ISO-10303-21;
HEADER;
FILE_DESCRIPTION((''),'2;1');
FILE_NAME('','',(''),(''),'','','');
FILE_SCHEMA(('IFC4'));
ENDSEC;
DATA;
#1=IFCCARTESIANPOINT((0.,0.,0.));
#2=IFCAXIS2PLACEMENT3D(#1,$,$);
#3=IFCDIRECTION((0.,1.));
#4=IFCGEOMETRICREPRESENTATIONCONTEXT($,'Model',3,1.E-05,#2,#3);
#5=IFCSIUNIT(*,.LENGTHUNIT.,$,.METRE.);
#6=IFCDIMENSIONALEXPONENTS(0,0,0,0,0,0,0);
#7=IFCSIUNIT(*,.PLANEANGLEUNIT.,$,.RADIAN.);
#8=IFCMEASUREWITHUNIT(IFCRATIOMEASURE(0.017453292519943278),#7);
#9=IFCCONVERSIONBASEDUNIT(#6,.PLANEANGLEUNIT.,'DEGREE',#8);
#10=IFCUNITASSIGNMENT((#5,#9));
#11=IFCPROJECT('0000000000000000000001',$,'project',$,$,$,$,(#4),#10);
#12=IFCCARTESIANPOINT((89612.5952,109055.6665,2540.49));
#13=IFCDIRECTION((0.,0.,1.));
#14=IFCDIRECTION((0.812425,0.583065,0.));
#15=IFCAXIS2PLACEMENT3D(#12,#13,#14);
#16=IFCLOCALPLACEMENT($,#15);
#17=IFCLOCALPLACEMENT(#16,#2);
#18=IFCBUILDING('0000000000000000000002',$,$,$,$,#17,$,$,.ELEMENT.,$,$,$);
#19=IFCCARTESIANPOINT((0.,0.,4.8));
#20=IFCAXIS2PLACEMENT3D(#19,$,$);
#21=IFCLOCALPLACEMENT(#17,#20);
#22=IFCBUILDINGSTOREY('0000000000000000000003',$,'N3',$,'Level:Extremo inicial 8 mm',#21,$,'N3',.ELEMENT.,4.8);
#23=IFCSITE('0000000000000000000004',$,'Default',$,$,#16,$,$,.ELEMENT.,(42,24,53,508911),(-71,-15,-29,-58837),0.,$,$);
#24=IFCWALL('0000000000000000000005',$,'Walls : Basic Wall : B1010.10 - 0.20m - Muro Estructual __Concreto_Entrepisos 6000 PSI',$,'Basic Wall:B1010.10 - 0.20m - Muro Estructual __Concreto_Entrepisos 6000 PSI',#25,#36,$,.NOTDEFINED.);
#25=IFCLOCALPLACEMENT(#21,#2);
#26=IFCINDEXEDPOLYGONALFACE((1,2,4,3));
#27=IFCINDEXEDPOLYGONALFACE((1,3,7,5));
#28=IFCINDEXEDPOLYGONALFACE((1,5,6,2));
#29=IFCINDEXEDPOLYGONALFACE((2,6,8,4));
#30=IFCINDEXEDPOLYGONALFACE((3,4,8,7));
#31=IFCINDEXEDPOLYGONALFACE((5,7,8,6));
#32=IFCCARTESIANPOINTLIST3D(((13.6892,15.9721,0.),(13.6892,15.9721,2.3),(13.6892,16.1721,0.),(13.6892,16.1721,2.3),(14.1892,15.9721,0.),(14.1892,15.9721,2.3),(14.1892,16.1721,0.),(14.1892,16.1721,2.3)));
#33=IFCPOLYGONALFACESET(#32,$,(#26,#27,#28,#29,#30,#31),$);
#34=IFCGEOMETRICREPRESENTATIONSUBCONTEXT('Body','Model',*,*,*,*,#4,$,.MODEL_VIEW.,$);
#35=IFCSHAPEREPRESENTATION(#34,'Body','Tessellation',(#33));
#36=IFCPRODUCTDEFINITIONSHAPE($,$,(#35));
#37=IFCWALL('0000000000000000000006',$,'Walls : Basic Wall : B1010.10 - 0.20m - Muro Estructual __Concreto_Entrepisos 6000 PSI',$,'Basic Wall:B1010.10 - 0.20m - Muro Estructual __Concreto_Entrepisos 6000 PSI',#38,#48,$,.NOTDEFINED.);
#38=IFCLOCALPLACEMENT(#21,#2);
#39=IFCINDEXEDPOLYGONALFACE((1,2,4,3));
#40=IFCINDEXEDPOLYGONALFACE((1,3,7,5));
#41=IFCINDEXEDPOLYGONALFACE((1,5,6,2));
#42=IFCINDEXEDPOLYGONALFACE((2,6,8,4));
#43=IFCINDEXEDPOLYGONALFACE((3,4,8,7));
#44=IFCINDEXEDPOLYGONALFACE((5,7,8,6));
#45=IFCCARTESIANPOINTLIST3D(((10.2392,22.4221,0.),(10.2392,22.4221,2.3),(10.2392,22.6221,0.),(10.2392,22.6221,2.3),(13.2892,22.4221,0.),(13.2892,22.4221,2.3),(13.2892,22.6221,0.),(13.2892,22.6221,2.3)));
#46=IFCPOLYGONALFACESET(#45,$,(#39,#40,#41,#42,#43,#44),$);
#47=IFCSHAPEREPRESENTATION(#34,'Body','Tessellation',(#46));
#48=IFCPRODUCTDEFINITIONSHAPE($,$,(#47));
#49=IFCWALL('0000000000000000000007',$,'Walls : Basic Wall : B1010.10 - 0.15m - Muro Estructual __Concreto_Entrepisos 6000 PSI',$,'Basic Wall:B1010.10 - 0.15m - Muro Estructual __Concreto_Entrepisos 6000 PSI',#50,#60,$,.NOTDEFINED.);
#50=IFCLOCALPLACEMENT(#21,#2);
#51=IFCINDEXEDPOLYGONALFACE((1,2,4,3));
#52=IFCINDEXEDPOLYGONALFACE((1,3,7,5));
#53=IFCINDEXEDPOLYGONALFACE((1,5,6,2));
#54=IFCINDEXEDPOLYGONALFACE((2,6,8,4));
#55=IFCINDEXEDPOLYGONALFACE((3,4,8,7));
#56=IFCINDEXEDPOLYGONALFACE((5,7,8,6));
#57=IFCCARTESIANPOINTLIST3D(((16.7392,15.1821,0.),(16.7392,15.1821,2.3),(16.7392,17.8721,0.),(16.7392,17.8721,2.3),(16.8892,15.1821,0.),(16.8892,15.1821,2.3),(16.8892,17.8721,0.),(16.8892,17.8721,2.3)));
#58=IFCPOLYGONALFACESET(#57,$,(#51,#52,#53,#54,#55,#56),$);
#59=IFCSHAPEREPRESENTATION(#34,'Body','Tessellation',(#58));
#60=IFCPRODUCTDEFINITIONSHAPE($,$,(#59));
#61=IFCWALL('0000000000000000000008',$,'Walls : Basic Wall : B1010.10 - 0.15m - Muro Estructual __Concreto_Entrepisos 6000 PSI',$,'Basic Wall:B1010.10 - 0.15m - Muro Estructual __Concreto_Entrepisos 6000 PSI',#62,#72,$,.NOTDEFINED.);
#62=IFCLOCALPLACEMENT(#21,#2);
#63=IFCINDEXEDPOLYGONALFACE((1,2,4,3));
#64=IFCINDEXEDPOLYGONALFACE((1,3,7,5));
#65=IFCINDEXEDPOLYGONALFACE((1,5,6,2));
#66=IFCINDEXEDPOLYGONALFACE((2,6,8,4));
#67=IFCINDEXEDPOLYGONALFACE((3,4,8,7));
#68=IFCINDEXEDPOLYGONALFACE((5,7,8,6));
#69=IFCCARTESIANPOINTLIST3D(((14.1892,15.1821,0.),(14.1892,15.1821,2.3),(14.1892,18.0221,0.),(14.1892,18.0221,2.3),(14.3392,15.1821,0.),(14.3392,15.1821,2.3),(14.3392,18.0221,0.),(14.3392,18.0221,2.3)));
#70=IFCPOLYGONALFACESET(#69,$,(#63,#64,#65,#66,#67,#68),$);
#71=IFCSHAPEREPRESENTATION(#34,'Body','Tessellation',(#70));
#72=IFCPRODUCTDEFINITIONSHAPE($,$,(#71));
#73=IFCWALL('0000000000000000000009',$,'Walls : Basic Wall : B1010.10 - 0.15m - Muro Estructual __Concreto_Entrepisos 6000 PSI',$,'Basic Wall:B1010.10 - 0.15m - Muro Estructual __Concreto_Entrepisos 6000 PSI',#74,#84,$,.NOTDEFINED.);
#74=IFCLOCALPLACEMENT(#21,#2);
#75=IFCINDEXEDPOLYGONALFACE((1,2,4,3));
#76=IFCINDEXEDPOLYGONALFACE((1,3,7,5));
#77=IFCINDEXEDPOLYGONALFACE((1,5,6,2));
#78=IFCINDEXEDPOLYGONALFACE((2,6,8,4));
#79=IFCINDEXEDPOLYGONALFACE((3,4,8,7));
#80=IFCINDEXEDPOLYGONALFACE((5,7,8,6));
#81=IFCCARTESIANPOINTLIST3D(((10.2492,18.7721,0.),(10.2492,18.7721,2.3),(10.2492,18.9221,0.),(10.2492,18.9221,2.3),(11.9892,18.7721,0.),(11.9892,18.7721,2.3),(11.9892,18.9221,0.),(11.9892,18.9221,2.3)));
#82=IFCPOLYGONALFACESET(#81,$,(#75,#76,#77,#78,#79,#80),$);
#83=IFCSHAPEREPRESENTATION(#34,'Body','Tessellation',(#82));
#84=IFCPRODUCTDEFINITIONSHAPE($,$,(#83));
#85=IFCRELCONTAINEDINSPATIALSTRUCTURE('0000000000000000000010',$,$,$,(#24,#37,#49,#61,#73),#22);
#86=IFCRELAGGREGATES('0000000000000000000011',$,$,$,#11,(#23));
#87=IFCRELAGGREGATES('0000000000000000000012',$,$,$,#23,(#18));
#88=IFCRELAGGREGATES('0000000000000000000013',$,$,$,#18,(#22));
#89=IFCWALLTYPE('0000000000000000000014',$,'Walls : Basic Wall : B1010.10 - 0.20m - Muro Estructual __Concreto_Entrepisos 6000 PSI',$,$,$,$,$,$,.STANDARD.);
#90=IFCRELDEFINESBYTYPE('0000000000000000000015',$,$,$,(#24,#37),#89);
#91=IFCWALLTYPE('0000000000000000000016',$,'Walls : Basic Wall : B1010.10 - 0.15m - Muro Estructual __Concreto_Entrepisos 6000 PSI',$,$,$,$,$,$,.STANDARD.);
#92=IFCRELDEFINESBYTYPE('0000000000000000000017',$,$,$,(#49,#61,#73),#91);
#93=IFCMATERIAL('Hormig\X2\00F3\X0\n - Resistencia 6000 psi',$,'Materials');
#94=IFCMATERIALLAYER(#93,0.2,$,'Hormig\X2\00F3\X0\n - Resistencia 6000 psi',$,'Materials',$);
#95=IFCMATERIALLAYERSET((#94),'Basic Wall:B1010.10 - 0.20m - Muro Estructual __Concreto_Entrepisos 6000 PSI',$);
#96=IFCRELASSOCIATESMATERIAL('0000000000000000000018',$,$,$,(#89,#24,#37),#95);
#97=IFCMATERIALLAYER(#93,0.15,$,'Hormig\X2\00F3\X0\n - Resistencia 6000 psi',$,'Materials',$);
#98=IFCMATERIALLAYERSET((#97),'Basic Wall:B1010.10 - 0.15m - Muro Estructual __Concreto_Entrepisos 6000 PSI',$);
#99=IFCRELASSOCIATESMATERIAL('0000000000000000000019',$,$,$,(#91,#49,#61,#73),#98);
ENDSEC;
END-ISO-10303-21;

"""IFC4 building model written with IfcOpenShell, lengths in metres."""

from ifc_helpers import new_model, entity, si_unit, converted_unit, direction, frame, frame_2d, origin, place, context, subcontext, project, spatial, rectangle, extrude, material, layer, layer_set, layer_usage, type_object, element, save


model = new_model("IFC4")

# Units and contexts
model_context = context("Model", 3, precision=1e-05, world=origin(), true_north=direction((0.0, 1.0)))
body_context = subcontext(model_context, "Body", "Model", "MODEL_VIEW")
ifc_project = project(units=[si_unit("LENGTHUNIT", "METRE"), converted_unit("PLANEANGLEUNIT", "DEGREE", entity("IfcRatioMeasure", 0.017453292519943278), si_unit("PLANEANGLEUNIT", "RADIAN"), dimensions=[0, 0, 0, 0, 0, 0, 0])], contexts=[model_context])

# Site, building, storey
site_placement = place(None, frame((89612.5952, 109055.6665, 2540.49), z_axis=(0.0, 0.0, 1.0), x_axis=(0.812425, 0.583065, 0.0)))
site = spatial("IfcSite", under=ifc_project, at=site_placement, Name="Default", CompositionType="ELEMENT", RefLatitude=(42, 24, 53, 508911), RefLongitude=(-71, -15, -29, -58837), RefElevation=0.0)
building_placement = place(site_placement, origin())
building = spatial("IfcBuilding", under=site, at=building_placement, CompositionType="ELEMENT")
storey_placement = place(building_placement, frame((0.0, 0.0, 4.8)))
storey = spatial("IfcBuildingStorey", under=building, at=storey_placement, Name="N3", ObjectType="Level:Extremo inicial 8 mm", LongName="N3", CompositionType="ELEMENT", Elevation=4.8)

# Walls
ifc_material_1 = material(Name="Hormigón - Resistencia 6000 psi", Category="Materials")
ifc_layer_1 = layer(ifc_material_1, 0.2, Name="Hormigón - Resistencia 6000 psi", Category="Materials")
ifc_layer_set_1 = layer_set([ifc_layer_1], Name="Basic Wall:B1010.10 - 0.20m - Muro Estructual __Concreto_Entrepisos 6000 PSI")
wall_type_1 = type_object("IfcWallType", Name="Walls : Basic Wall : B1010.10 - 0.20m - Muro Estructual __Concreto_Entrepisos 6000 PSI", PredefinedType="STANDARD", material=ifc_layer_set_1)
ifc_layer_usage_1 = layer_usage(ifc_layer_set_1, "AXIS2", "NEGATIVE", 0.1)
wall_1_placement = place(storey_placement, frame((13.6892, 16.0721, 0.0)))
element("IfcWall", 1, at=wall_1_placement, inside=storey, type_object=wall_type_1, material=ifc_layer_usage_1, Name="Walls : Basic Wall : B1010.10 - 0.20m - Muro Estructual __Concreto_Entrepisos 6000 PSI", ObjectType="Basic Wall:B1010.10 - 0.20m - Muro Estructual __Concreto_Entrepisos 6000 PSI", PredefinedType="NOTDEFINED", context=body_context, shape_type="SweptSolid", body=[
    extrude(rectangle(XDim=0.5, YDim=0.2, at=frame_2d((0.25, 0.0), x_axis=(-1.0, 0.0))), origin(), (0.0, 0.0, 1.0), 2.3),
])
ifc_layer_usage_2 = layer_usage(ifc_layer_set_1, "AXIS2", "POSITIVE", -0.1)
wall_2_placement = place(storey_placement, frame((10.2392, 22.5221, 0.0)))
element("IfcWall", 2, at=wall_2_placement, inside=storey, type_object=wall_type_1, material=ifc_layer_usage_2, Name="Walls : Basic Wall : B1010.10 - 0.20m - Muro Estructual __Concreto_Entrepisos 6000 PSI", ObjectType="Basic Wall:B1010.10 - 0.20m - Muro Estructual __Concreto_Entrepisos 6000 PSI", PredefinedType="NOTDEFINED", context=body_context, shape_type="SweptSolid", body=[
    extrude(rectangle(XDim=3.05, YDim=0.2, at=frame_2d((1.525, 0.0), x_axis=(-1.0, 0.0))), origin(), (0.0, 0.0, 1.0), 2.3),
])
ifc_layer_2 = layer(ifc_material_1, 0.15, Name="Hormigón - Resistencia 6000 psi", Category="Materials")
ifc_layer_set_2 = layer_set([ifc_layer_2], Name="Basic Wall:B1010.10 - 0.15m - Muro Estructual __Concreto_Entrepisos 6000 PSI")
ifc_layer_usage_3 = layer_usage(ifc_layer_set_2, "AXIS2", "NEGATIVE", 0.075)
wall_type_2 = type_object("IfcWallType", Name="Walls : Basic Wall : B1010.10 - 0.15m - Muro Estructual __Concreto_Entrepisos 6000 PSI", PredefinedType="STANDARD", material=ifc_layer_set_2)
wall_3_placement = place(storey_placement, frame((16.8142, 15.1821, 0.0), z_axis=(0.0, 0.0, 1.0), x_axis=(0.0, 1.0, 0.0)))
element("IfcWall", 3, at=wall_3_placement, inside=storey, type_object=wall_type_2, material=ifc_layer_usage_3, Name="Walls : Basic Wall : B1010.10 - 0.15m - Muro Estructual __Concreto_Entrepisos 6000 PSI", ObjectType="Basic Wall:B1010.10 - 0.15m - Muro Estructual __Concreto_Entrepisos 6000 PSI", PredefinedType="NOTDEFINED", context=body_context, shape_type="SweptSolid", body=[
    extrude(rectangle(XDim=2.69, YDim=0.15, at=frame_2d((1.345, 0.0), x_axis=(-1.0, 0.0))), origin(), (0.0, 0.0, 1.0), 2.3),
])
ifc_layer_usage_4 = layer_usage(ifc_layer_set_2, "AXIS2", "NEGATIVE", 0.075)
wall_4_placement = place(storey_placement, frame((14.2642, 15.1821, 0.0), z_axis=(0.0, 0.0, 1.0), x_axis=(0.0, 1.0, 0.0)))
element("IfcWall", 4, at=wall_4_placement, inside=storey, type_object=wall_type_2, material=ifc_layer_usage_4, Name="Walls : Basic Wall : B1010.10 - 0.15m - Muro Estructual __Concreto_Entrepisos 6000 PSI", ObjectType="Basic Wall:B1010.10 - 0.15m - Muro Estructual __Concreto_Entrepisos 6000 PSI", PredefinedType="NOTDEFINED", context=body_context, shape_type="SweptSolid", body=[
    extrude(rectangle(XDim=2.84, YDim=0.15, at=frame_2d((1.42, 0.0), x_axis=(-1.0, 0.0))), origin(), (0.0, 0.0, 1.0), 2.3),
])
ifc_layer_usage_5 = layer_usage(ifc_layer_set_2, "AXIS2", "NEGATIVE", 0.075)
wall_5_placement = place(storey_placement, frame((11.9892, 18.8471, 0.0), z_axis=(0.0, 0.0, 1.0), x_axis=(-1.0, 0.0, 0.0)))
element("IfcWall", 5, at=wall_5_placement, inside=storey, type_object=wall_type_2, material=ifc_layer_usage_5, Name="Walls : Basic Wall : B1010.10 - 0.15m - Muro Estructual __Concreto_Entrepisos 6000 PSI", ObjectType="Basic Wall:B1010.10 - 0.15m - Muro Estructual __Concreto_Entrepisos 6000 PSI", PredefinedType="NOTDEFINED", context=body_context, shape_type="SweptSolid", body=[
    extrude(rectangle(XDim=1.74, YDim=0.15, at=frame_2d((0.87, 0.0), x_axis=(-1.0, 0.0))), origin(), (0.0, 0.0, 1.0), 2.3),
])

save(model, "model.ifc")
